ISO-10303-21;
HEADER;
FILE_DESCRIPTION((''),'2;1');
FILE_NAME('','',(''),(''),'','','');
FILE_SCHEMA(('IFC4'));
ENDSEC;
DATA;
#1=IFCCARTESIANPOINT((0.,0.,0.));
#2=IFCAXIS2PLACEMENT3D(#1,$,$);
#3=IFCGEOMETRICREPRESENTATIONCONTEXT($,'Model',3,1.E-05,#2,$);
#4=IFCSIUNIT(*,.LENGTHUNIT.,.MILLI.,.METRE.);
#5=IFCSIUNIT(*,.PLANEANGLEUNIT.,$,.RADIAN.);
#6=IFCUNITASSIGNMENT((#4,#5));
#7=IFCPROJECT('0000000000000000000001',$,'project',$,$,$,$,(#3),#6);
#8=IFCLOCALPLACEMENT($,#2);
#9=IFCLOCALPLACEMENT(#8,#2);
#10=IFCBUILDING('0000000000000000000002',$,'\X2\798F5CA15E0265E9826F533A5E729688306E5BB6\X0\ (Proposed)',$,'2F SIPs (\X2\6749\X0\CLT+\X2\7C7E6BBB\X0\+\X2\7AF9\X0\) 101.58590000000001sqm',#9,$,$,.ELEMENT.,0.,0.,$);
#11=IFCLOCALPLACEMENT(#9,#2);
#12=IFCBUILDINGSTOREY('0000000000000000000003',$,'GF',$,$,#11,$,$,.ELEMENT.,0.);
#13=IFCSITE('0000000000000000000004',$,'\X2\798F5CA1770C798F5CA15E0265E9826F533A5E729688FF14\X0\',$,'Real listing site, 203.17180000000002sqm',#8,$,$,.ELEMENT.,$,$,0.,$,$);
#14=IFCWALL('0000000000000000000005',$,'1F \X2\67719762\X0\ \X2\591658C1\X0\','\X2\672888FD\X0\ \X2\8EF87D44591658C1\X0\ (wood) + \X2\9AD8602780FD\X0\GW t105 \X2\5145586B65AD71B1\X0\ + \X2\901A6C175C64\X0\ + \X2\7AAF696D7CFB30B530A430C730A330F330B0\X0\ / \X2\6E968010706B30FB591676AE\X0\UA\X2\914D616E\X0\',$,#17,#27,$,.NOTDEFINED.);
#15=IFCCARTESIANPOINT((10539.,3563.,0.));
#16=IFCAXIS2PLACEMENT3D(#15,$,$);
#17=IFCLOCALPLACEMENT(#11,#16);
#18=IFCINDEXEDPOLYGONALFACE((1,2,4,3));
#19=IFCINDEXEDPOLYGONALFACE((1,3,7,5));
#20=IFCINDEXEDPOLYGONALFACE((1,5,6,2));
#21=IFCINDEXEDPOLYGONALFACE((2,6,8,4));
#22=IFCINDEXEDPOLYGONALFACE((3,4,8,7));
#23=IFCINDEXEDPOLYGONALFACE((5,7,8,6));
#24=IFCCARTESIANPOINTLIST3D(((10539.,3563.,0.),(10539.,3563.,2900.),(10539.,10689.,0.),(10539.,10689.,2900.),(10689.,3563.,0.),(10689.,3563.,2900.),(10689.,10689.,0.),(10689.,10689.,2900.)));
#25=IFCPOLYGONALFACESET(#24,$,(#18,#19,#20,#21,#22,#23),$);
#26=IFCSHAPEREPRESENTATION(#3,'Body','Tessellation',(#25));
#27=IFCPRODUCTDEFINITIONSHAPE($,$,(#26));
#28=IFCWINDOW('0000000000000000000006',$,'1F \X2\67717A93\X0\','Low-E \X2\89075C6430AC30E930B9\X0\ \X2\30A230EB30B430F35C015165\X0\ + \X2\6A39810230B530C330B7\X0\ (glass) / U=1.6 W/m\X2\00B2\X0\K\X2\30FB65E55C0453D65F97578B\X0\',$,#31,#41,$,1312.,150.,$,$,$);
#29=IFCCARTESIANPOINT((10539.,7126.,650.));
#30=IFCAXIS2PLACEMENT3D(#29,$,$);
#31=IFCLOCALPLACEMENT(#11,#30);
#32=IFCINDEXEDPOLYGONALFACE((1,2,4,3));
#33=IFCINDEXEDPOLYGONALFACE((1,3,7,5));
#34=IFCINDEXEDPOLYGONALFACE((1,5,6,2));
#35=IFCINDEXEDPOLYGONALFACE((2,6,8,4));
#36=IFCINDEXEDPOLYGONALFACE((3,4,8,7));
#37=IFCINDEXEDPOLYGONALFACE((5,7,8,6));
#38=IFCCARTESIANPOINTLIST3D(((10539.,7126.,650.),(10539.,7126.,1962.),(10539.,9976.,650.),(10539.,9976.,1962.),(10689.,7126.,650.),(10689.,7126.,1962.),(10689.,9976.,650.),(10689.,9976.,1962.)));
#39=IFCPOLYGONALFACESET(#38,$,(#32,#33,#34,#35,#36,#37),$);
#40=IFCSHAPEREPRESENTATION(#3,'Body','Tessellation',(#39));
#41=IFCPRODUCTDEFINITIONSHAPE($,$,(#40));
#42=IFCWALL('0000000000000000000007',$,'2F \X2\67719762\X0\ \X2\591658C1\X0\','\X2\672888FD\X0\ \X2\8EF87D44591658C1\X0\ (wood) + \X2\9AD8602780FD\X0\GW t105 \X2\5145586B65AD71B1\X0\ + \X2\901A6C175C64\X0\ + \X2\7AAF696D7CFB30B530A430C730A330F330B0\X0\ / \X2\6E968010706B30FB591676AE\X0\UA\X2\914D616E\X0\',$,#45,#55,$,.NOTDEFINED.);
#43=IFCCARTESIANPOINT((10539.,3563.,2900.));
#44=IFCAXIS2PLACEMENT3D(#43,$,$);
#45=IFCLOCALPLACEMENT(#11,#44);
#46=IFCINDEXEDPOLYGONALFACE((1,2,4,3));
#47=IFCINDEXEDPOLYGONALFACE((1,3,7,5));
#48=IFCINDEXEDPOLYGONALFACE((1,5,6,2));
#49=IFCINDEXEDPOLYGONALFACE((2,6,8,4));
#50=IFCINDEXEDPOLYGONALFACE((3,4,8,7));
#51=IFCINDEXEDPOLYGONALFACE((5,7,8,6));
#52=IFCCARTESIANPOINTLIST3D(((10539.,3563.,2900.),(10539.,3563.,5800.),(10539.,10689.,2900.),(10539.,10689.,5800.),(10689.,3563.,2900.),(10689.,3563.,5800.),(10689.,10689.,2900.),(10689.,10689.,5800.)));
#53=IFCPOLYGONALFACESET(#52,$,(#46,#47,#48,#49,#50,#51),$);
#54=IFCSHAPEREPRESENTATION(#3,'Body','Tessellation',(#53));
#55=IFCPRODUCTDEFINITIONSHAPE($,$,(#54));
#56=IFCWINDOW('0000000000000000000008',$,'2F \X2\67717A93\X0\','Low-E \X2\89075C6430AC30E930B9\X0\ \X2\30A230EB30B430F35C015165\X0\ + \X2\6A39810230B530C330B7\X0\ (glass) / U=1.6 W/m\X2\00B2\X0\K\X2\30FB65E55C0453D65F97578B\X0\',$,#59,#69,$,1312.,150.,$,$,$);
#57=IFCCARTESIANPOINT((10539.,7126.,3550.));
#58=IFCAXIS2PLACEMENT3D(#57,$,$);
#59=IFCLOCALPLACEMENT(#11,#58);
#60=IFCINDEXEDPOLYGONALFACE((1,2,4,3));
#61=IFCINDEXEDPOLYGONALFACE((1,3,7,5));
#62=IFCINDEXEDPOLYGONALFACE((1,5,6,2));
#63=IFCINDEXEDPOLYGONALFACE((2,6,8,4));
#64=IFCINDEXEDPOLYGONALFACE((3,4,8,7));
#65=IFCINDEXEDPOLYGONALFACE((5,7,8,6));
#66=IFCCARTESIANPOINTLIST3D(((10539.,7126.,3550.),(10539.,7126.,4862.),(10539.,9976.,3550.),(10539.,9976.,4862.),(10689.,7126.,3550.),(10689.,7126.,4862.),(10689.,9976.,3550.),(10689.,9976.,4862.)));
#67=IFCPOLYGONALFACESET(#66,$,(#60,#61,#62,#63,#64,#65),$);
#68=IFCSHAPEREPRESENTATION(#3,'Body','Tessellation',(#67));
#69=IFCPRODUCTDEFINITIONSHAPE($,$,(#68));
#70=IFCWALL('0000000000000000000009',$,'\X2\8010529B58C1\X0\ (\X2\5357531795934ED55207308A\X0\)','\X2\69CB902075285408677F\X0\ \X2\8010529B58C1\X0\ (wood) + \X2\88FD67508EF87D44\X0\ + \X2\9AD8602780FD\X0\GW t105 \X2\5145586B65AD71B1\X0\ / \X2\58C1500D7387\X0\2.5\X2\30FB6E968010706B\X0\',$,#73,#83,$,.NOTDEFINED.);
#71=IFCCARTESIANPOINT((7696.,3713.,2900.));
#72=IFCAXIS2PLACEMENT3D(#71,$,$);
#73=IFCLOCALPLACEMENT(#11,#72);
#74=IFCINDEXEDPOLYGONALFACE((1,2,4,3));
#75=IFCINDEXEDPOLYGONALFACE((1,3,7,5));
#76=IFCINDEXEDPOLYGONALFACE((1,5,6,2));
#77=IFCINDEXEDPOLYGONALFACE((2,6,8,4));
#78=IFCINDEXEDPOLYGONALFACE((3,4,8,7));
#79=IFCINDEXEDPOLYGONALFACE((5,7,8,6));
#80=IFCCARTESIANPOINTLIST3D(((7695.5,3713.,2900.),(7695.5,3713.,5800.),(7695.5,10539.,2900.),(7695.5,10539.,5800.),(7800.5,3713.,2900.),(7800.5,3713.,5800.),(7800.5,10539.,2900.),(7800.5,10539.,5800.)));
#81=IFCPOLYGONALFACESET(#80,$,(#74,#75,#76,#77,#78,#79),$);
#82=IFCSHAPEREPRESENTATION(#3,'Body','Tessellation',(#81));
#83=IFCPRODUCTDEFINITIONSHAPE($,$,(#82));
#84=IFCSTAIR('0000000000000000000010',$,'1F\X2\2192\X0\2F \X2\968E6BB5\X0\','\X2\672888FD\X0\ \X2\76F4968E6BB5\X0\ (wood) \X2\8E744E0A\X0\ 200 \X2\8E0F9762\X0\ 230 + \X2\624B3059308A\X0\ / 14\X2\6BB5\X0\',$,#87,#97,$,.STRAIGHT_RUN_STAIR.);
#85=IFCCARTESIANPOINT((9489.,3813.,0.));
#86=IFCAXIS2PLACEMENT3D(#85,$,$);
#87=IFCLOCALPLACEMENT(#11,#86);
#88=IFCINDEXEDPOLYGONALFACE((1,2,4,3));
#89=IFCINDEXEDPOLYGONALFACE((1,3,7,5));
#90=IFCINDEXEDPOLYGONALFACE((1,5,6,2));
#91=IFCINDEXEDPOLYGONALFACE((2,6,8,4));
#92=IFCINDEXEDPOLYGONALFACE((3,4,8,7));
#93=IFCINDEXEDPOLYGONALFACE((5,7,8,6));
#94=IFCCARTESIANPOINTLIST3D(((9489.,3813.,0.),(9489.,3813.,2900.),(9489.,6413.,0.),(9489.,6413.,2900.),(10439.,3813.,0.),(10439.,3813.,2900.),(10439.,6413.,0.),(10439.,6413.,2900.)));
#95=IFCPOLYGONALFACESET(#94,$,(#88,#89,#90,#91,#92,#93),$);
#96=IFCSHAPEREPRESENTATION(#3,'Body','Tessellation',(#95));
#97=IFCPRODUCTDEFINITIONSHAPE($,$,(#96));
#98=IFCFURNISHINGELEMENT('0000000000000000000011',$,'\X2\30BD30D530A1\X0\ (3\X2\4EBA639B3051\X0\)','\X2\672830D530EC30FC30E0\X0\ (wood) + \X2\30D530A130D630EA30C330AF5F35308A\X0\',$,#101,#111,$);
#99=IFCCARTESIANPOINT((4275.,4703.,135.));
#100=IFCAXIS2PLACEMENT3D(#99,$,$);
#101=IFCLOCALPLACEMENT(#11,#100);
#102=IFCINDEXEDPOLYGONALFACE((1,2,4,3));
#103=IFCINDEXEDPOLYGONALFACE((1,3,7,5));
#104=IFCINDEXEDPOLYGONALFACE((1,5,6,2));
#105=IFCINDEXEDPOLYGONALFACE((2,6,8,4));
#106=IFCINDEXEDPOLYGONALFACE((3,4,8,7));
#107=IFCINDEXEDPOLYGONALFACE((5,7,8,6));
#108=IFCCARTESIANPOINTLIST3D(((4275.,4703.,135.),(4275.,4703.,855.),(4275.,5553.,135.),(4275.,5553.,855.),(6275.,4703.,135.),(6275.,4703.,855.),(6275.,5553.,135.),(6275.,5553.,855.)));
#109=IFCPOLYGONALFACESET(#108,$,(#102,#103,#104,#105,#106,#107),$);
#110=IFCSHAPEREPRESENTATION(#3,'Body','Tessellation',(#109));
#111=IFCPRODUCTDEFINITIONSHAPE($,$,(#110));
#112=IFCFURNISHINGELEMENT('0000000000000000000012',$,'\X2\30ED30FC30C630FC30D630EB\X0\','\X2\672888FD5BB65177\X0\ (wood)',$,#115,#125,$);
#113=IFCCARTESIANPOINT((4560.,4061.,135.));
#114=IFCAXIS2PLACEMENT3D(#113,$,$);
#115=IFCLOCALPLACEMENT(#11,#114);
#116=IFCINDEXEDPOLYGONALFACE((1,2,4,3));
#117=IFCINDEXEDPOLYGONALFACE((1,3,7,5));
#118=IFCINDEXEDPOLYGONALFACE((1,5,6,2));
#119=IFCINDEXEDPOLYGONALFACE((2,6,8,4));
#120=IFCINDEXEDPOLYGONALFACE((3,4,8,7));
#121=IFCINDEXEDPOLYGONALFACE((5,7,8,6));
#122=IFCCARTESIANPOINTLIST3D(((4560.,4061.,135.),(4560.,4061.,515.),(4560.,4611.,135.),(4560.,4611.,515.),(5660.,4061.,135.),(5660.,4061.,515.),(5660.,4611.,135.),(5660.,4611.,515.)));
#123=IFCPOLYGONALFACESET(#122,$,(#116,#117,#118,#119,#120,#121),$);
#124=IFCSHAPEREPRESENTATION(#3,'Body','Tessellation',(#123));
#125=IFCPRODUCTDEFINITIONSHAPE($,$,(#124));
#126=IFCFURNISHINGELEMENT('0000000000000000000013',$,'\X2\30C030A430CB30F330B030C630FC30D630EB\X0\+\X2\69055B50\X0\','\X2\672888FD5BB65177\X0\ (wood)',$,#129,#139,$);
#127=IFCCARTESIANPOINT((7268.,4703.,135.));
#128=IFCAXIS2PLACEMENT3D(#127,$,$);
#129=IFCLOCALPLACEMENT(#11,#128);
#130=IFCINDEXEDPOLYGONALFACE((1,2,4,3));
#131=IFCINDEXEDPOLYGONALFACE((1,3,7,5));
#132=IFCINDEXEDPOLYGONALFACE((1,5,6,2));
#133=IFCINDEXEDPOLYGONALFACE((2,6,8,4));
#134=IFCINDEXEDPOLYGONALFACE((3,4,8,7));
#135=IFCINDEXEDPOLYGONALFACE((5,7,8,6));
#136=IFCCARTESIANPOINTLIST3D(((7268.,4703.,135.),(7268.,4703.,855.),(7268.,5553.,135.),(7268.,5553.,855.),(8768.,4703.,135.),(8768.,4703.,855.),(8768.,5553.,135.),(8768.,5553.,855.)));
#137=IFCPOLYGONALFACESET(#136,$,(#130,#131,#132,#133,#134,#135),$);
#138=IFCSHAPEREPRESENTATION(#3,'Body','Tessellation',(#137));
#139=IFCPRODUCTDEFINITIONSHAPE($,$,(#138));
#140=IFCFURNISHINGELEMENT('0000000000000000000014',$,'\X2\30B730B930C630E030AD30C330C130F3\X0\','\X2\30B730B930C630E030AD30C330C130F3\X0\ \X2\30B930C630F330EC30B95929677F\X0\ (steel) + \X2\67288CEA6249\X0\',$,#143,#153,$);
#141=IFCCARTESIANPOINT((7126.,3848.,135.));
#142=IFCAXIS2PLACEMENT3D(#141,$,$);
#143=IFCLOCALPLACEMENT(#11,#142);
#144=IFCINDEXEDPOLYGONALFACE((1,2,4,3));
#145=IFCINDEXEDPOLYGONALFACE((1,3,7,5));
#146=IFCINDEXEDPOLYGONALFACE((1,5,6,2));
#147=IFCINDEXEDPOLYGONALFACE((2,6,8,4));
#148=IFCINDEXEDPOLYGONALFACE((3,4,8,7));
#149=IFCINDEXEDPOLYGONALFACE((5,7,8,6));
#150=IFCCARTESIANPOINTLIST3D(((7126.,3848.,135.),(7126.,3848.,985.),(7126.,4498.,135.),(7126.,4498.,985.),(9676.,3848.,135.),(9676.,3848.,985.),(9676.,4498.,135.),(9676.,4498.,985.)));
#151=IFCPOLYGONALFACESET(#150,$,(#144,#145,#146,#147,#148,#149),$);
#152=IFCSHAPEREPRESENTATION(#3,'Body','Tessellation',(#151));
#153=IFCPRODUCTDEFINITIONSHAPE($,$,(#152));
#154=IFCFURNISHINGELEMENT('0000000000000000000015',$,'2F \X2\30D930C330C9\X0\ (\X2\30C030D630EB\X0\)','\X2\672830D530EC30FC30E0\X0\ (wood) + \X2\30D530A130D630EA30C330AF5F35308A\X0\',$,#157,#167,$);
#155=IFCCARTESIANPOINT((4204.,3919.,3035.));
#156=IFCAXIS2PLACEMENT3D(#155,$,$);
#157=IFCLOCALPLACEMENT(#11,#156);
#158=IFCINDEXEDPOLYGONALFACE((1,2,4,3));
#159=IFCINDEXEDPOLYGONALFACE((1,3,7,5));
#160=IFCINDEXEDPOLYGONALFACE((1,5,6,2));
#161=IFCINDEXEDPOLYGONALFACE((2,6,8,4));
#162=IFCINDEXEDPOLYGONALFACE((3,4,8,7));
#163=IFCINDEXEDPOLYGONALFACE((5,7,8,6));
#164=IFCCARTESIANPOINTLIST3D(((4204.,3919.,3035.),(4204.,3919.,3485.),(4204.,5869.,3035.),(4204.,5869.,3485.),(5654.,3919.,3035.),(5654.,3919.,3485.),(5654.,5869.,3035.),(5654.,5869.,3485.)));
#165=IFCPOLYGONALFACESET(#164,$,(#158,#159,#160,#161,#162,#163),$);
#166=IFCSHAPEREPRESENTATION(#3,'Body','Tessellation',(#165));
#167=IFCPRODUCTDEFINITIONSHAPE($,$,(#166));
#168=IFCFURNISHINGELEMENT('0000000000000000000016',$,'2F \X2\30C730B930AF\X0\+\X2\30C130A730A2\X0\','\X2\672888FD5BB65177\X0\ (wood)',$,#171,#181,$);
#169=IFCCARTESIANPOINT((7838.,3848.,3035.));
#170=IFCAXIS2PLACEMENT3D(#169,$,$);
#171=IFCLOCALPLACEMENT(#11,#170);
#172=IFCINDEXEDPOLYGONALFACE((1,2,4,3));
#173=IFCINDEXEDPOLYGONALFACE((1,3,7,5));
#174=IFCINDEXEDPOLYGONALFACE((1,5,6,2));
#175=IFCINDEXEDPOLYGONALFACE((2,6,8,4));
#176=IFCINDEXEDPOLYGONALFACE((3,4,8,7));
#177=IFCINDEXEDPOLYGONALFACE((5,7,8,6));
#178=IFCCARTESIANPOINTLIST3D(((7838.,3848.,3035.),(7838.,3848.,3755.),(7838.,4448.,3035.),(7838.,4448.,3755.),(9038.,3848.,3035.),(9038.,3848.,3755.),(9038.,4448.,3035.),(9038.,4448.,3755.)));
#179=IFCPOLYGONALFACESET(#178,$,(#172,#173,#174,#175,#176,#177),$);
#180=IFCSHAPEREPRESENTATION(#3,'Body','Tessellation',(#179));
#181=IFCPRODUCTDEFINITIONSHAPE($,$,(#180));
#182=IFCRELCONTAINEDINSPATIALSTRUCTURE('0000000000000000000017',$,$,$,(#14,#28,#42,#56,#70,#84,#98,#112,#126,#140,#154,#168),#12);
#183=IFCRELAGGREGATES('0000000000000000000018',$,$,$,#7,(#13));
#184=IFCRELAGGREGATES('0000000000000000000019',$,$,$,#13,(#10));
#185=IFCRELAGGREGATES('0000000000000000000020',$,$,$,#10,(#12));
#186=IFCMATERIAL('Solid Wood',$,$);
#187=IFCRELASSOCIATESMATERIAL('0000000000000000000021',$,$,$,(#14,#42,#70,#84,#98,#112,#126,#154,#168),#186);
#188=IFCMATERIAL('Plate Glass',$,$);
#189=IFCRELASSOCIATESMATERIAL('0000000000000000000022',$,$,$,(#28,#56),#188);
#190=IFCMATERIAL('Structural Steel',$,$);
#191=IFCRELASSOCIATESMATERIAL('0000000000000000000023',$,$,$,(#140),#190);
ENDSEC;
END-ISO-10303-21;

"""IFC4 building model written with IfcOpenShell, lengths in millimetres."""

from ifc_helpers import new_model, si_unit, frame, frame_2d, origin, place, context, project, spatial, rectangle, extrude, material, element, fill, save


model = new_model("IFC4")

# Units and contexts
model_context = context("Model", 3, precision=1e-05, world=origin())
ifc_project = project(units=[si_unit("LENGTHUNIT", "METRE", prefix="MILLI"), si_unit("PLANEANGLEUNIT", "RADIAN")], contexts=[model_context])

# Site, building, storey
site_placement = place(None, origin())
site = spatial("IfcSite", under=ifc_project, at=site_placement, Name="福岡県福岡市早良区干隈４", ObjectType="Real listing site, 203.17180000000002sqm", CompositionType="ELEMENT", RefElevation=0.0)
building_placement = place(site_placement, origin())
building = spatial("IfcBuilding", under=site, at=building_placement, Name="福岡市早良区干隈の家 (Proposed)", ObjectType="2F SIPs (杉CLT+籾殻+竹) 101.58590000000001sqm", CompositionType="ELEMENT", ElevationOfRefHeight=0.0, ElevationOfTerrain=0.0)
storey_placement = place(building_placement, origin())
storey = spatial("IfcBuildingStorey", under=building, at=storey_placement, Name="GF", CompositionType="ELEMENT", Elevation=0.0)

# Wall, opening, window
ifc_material_1 = material(Name="Solid Wood")
wall_1_placement = place(storey_placement, frame((10539.0, 3563.0, 0.0)))
wall_1 = element("IfcWall", 1, at=wall_1_placement, inside=storey, material=ifc_material_1, Name="1F 東面 外壁", Description="木製 軸組外壁 (wood) + 高性能GW t105 充填断熱 + 通気層 + 窯業系サイディング / 準耐火・外皮UA配慮", PredefinedType="NOTDEFINED", context=model_context, shape_type="SweptSolid", body=[
    extrude(rectangle(XDim=150.0, YDim=7126.0, at=frame_2d((75.0, 3563.0))), frame((10539.0, 3563.0, 0.0)), (0.0, 0.0, 1.0), 2900.0),
])
opening_1_placement = place(storey_placement, frame((10539.0, 7126.0, 650.0)))
opening_1 = element("IfcOpeningElement", 2, at=opening_1_placement, cuts=wall_1, PredefinedType="NOTDEFINED", context=model_context, shape_type="SweptSolid", body=[
    extrude(rectangle(XDim=150.0, YDim=2850.0, at=frame_2d((75.0, 1425.0))), frame((10539.0, 7126.0, 650.0)), (0.0, 0.0, 1.0), 1312.0),
])
ifc_material_2 = material(Name="Plate Glass")
window_1_placement = place(storey_placement, frame((10539.0, 7126.0, 650.0)))
window_1 = element("IfcWindow", 3, at=window_1_placement, inside=storey, material=ifc_material_2, Name="1F 東窓", Description="Low-E 複層ガラス アルゴン封入 + 樹脂サッシ (glass) / U=1.6 W/m²K・日射取得型", OverallHeight=1312.0, OverallWidth=150.0, context=model_context, shape_type="SweptSolid", body=[
    extrude(rectangle(XDim=150.0, YDim=2850.0, at=frame_2d((75.0, 1425.0))), frame((10539.0, 7126.0, 650.0)), (0.0, 0.0, 1.0), 1312.0),
])
fill(opening_1, window_1)

# Wall, opening, window
wall_2_placement = place(storey_placement, frame((10539.0, 3563.0, 2900.0)))
wall_2 = element("IfcWall", 4, at=wall_2_placement, inside=storey, material=ifc_material_1, Name="2F 東面 外壁", Description="木製 軸組外壁 (wood) + 高性能GW t105 充填断熱 + 通気層 + 窯業系サイディング / 準耐火・外皮UA配慮", PredefinedType="NOTDEFINED", context=model_context, shape_type="SweptSolid", body=[
    extrude(rectangle(XDim=150.0, YDim=7126.0, at=frame_2d((75.0, 3563.0))), frame((10539.0, 3563.0, 2900.0)), (0.0, 0.0, 1.0), 2900.0),
])
opening_2_placement = place(storey_placement, frame((10539.0, 7126.0, 3550.0)))
opening_2 = element("IfcOpeningElement", 5, at=opening_2_placement, cuts=wall_2, PredefinedType="NOTDEFINED", context=model_context, shape_type="SweptSolid", body=[
    extrude(rectangle(XDim=150.0, YDim=2850.0, at=frame_2d((75.0, 1425.0))), frame((10539.0, 7126.0, 3550.0)), (0.0, 0.0, 1.0), 1312.0),
])
window_2_placement = place(storey_placement, frame((10539.0, 7126.0, 3550.0)))
window_2 = element("IfcWindow", 6, at=window_2_placement, inside=storey, material=ifc_material_2, Name="2F 東窓", Description="Low-E 複層ガラス アルゴン封入 + 樹脂サッシ (glass) / U=1.6 W/m²K・日射取得型", OverallHeight=1312.0, OverallWidth=150.0, context=model_context, shape_type="SweptSolid", body=[
    extrude(rectangle(XDim=150.0, YDim=2850.0, at=frame_2d((75.0, 1425.0))), frame((10539.0, 7126.0, 3550.0)), (0.0, 0.0, 1.0), 1312.0),
])
fill(opening_2, window_2)

# Wall
wall_3_placement = place(storey_placement, frame((7696.0, 3713.0, 2900.0)))
element("IfcWall", 7, at=wall_3_placement, inside=storey, material=ifc_material_1, Name="耐力壁 (南北間仕切り)", Description="構造用合板 耐力壁 (wood) + 製材軸組 + 高性能GW t105 充填断熱 / 壁倍率2.5・準耐火", PredefinedType="NOTDEFINED", context=model_context, shape_type="SweptSolid", body=[
    extrude(rectangle(XDim=105.0, YDim=6826.0, at=frame_2d((52.0, 3413.0))), frame((7696.0, 3713.0, 2900.0)), (0.0, 0.0, 1.0), 2900.0),
])

# Stair
stair_placement = place(storey_placement, frame((9489.0, 3813.0, 0.0)))
element("IfcStair", 8, at=stair_placement, inside=storey, material=ifc_material_1, Name="1F→2F 階段", Description="木製 直階段 (wood) 蹴上 200 踏面 230 + 手すり / 14段", PredefinedType="STRAIGHT_RUN_STAIR", context=model_context, shape_type="SweptSolid", body=[
    extrude(rectangle(XDim=950.0, YDim=2600.0, at=frame_2d((475.0, 1300.0))), frame((9489.0, 3813.0, 0.0)), (0.0, 0.0, 1.0), 2900.0),
])

# Furnishing elements
furnishing_1_placement = place(storey_placement, frame((4275.0, 4703.0, 135.0)))
element("IfcFurnishingElement", 9, at=furnishing_1_placement, inside=storey, material=ifc_material_1, Name="ソファ (3人掛け)", Description="木フレーム (wood) + ファブリック張り", context=model_context, shape_type="SweptSolid", body=[
    extrude(rectangle(XDim=2000.0, YDim=850.0, at=frame_2d((1000.0, 425.0))), frame((4275.0, 4703.0, 135.0)), (0.0, 0.0, 1.0), 720.0),
])
furnishing_2_placement = place(storey_placement, frame((4560.0, 4061.0, 135.0)))
element("IfcFurnishingElement", 10, at=furnishing_2_placement, inside=storey, material=ifc_material_1, Name="ローテーブル", Description="木製家具 (wood)", context=model_context, shape_type="SweptSolid", body=[
    extrude(rectangle(XDim=1100.0, YDim=550.0, at=frame_2d((550.0, 275.0))), frame((4560.0, 4061.0, 135.0)), (0.0, 0.0, 1.0), 380.0),
])
furnishing_3_placement = place(storey_placement, frame((7268.0, 4703.0, 135.0)))
element("IfcFurnishingElement", 11, at=furnishing_3_placement, inside=storey, material=ifc_material_1, Name="ダイニングテーブル+椅子", Description="木製家具 (wood)", context=model_context, shape_type="SweptSolid", body=[
    extrude(rectangle(XDim=1500.0, YDim=850.0, at=frame_2d((750.0, 425.0))), frame((7268.0, 4703.0, 135.0)), (0.0, 0.0, 1.0), 720.0),
])
ifc_material_3 = material(Name="Structural Steel")
furnishing_4_placement = place(storey_placement, frame((7126.0, 3848.0, 135.0)))
element("IfcFurnishingElement", 12, at=furnishing_4_placement, inside=storey, material=ifc_material_3, Name="システムキッチン", Description="システムキッチン ステンレス天板 (steel) + 木質扉", context=model_context, shape_type="SweptSolid", body=[
    extrude(rectangle(XDim=2550.0, YDim=650.0, at=frame_2d((1275.0, 325.0))), frame((7126.0, 3848.0, 135.0)), (0.0, 0.0, 1.0), 850.0),
])
furnishing_5_placement = place(storey_placement, frame((4204.0, 3919.0, 3035.0)))
element("IfcFurnishingElement", 13, at=furnishing_5_placement, inside=storey, material=ifc_material_1, Name="2F ベッド (ダブル)", Description="木フレーム (wood) + ファブリック張り", context=model_context, shape_type="SweptSolid", body=[
    extrude(rectangle(XDim=1450.0, YDim=1950.0, at=frame_2d((725.0, 975.0))), frame((4204.0, 3919.0, 3035.0)), (0.0, 0.0, 1.0), 450.0),
])
furnishing_6_placement = place(storey_placement, frame((7838.0, 3848.0, 3035.0)))
element("IfcFurnishingElement", 14, at=furnishing_6_placement, inside=storey, material=ifc_material_1, Name="2F デスク+チェア", Description="木製家具 (wood)", context=model_context, shape_type="SweptSolid", body=[
    extrude(rectangle(XDim=1200.0, YDim=600.0, at=frame_2d((600.0, 300.0))), frame((7838.0, 3848.0, 3035.0)), (0.0, 0.0, 1.0), 720.0),
])

save(model, "model.ifc")
